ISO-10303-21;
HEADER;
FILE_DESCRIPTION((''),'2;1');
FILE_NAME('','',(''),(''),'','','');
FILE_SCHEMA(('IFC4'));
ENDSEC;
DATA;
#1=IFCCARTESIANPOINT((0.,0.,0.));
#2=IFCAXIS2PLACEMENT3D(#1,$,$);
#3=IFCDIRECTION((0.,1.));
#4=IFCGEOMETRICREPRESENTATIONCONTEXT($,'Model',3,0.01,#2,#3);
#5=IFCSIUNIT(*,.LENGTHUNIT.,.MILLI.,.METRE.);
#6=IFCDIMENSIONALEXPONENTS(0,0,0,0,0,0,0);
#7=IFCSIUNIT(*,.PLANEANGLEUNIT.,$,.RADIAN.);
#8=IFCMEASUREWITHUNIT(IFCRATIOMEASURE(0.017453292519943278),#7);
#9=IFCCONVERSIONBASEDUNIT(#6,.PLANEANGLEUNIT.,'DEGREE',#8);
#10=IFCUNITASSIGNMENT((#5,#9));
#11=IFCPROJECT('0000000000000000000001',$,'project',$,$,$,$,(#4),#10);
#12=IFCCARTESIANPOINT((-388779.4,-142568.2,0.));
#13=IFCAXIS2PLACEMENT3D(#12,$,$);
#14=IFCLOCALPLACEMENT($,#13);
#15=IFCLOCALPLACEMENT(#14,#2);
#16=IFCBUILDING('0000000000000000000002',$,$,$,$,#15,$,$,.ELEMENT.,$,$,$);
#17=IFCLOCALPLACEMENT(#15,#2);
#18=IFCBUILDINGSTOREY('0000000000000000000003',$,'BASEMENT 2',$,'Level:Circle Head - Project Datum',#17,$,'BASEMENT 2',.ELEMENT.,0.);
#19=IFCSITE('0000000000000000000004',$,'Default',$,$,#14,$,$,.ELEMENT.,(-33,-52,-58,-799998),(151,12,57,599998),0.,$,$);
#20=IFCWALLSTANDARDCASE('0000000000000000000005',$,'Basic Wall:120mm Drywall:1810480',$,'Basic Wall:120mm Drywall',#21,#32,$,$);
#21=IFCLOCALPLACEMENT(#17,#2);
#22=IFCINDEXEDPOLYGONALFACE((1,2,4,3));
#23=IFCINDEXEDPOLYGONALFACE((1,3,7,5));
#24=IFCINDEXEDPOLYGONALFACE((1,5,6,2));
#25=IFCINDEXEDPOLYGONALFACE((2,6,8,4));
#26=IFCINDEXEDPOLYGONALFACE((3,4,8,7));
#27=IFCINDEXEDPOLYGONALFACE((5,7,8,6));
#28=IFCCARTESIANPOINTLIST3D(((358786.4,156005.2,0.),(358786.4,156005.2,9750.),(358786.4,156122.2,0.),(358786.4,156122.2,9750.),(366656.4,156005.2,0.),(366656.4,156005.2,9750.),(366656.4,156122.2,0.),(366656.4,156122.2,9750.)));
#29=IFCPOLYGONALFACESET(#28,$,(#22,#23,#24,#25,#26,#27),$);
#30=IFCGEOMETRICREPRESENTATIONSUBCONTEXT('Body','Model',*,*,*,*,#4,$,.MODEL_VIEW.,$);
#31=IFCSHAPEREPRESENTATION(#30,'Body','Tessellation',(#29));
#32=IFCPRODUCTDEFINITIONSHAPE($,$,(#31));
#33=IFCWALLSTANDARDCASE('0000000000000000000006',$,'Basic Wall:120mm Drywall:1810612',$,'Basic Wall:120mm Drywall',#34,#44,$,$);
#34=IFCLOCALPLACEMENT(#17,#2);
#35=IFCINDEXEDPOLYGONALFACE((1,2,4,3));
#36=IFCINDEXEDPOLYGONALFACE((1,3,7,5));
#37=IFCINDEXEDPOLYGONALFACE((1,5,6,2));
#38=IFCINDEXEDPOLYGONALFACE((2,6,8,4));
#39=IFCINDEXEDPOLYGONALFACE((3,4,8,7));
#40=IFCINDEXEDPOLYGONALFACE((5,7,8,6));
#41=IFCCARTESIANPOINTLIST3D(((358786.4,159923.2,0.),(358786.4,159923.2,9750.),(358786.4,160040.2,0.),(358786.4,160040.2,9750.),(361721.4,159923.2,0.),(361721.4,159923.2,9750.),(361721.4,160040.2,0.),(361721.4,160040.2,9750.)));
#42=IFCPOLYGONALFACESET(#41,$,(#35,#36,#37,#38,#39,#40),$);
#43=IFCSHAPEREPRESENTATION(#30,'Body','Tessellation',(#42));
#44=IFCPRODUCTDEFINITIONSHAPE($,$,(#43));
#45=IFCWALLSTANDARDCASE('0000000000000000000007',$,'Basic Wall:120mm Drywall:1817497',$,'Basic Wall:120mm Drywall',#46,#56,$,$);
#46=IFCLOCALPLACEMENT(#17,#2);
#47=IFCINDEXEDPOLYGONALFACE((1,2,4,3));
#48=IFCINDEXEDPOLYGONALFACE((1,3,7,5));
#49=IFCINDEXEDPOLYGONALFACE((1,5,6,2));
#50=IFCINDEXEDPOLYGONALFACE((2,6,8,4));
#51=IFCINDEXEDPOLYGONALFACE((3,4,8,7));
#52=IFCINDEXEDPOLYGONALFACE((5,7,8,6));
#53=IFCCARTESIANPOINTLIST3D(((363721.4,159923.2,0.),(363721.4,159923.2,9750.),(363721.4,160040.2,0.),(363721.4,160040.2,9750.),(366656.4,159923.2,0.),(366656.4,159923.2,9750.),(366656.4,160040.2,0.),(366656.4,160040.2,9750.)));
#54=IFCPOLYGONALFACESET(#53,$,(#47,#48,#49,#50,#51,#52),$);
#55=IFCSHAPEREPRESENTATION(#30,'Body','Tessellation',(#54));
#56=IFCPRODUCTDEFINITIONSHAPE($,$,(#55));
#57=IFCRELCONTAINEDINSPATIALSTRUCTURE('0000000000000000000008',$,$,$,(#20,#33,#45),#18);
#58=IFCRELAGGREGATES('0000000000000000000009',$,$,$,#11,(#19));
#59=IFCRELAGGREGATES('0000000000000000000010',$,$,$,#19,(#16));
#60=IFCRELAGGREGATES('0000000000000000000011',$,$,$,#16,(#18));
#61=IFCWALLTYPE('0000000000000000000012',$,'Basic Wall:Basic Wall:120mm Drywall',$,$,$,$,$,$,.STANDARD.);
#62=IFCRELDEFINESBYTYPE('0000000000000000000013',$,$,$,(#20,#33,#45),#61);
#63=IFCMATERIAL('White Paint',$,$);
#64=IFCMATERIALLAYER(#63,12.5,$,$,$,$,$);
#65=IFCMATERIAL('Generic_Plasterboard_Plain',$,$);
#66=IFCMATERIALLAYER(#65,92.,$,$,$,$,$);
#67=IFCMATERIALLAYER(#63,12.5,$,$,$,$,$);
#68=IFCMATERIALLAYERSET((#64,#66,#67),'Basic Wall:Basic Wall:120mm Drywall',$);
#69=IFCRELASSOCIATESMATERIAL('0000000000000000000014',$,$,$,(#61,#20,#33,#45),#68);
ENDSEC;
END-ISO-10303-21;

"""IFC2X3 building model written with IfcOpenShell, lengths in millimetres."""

from ifc_helpers import new_model, entity, si_unit, converted_unit, direction, frame, frame_2d, origin, place, context, subcontext, project, spatial, rectangle, extrude, material, layer, layer_set, layer_usage, type_object, element, save


model = new_model("IFC2X3")

# Units and contexts
model_context = context("Model", 3, precision=0.01, world=origin(), true_north=direction((0.0, 1.0)))
body_context = subcontext(model_context, "Body", "Model", "MODEL_VIEW")
ifc_project = project(units=[si_unit("LENGTHUNIT", "METRE", prefix="MILLI"), converted_unit("PLANEANGLEUNIT", "DEGREE", entity("IfcRatioMeasure", 0.017453292519943278), si_unit("PLANEANGLEUNIT", "RADIAN"), dimensions=[0, 0, 0, 0, 0, 0, 0])], contexts=[model_context])

# Site, building, storey
site_placement = place(None, frame((-388779.4, -142568.2, 0.0)))
site = spatial("IfcSite", under=ifc_project, at=site_placement, Name="Default", CompositionType="ELEMENT", RefLatitude=(-33, -52, -58, -799998), RefLongitude=(151, 12, 57, 599998), RefElevation=0.0)
building_placement = place(site_placement, origin())
building = spatial("IfcBuilding", under=site, at=building_placement, CompositionType="ELEMENT")
storey_placement = place(building_placement, origin())
storey = spatial("IfcBuildingStorey", under=building, at=storey_placement, Name="BASEMENT 2", ObjectType="Level:Circle Head - Project Datum", LongName="BASEMENT 2", CompositionType="ELEMENT", Elevation=0.0)

# Shared definitions
ifc_material_1 = material(Name="White Paint")
ifc_layer_1 = layer(ifc_material_1, 12.5)
ifc_material_2 = material(Name="Generic_Plasterboard_Plain")
ifc_layer_2 = layer(ifc_material_2, 92.0)
ifc_layer_3 = layer(ifc_material_1, 12.5)
ifc_layer_set_1 = layer_set([ifc_layer_1, ifc_layer_2, ifc_layer_3], Name="Basic Wall:Basic Wall:120mm Drywall")
wall_type_1 = type_object("IfcWallType", Name="Basic Wall:Basic Wall:120mm Drywall", PredefinedType="STANDARD", material=ifc_layer_set_1)

# Walls
ifc_layer_usage_1 = layer_usage(ifc_layer_set_1, "AXIS2", "NEGATIVE", 58.5)
wall_1_placement = place(storey_placement, frame((358786.4, 156063.7, 0.0)))
element("IfcWallStandardCase", 1, at=wall_1_placement, inside=storey, type_object=wall_type_1, material=ifc_layer_usage_1, Name="Basic Wall:120mm Drywall:1810480", ObjectType="Basic Wall:120mm Drywall", context=body_context, shape_type="SweptSolid", body=[
    extrude(rectangle(XDim=7870.0, YDim=117.0, at=frame_2d((3935.0, 0.0), x_axis=(-1.0, 0.0))), origin(), (0.0, 0.0, 1.0), 9750.0),
])
ifc_layer_usage_2 = layer_usage(ifc_layer_set_1, "AXIS2", "NEGATIVE", 58.5)
wall_2_placement = place(storey_placement, frame((358786.4, 159981.7, 0.0)))
element("IfcWallStandardCase", 2, at=wall_2_placement, inside=storey, type_object=wall_type_1, material=ifc_layer_usage_2, Name="Basic Wall:120mm Drywall:1810612", ObjectType="Basic Wall:120mm Drywall", context=body_context, shape_type="SweptSolid", body=[
    extrude(rectangle(XDim=2935.0, YDim=117.0, at=frame_2d((1467.5, 0.0), x_axis=(-1.0, 0.0))), origin(), (0.0, 0.0, 1.0), 9750.0),
])
ifc_layer_usage_3 = layer_usage(ifc_layer_set_1, "AXIS2", "NEGATIVE", 58.5)
wall_3_placement = place(storey_placement, frame((363721.4, 159981.7, 0.0)))
element("IfcWallStandardCase", 3, at=wall_3_placement, inside=storey, type_object=wall_type_1, material=ifc_layer_usage_3, Name="Basic Wall:120mm Drywall:1817497", ObjectType="Basic Wall:120mm Drywall", context=body_context, shape_type="SweptSolid", body=[
    extrude(rectangle(XDim=2935.0, YDim=117.0, at=frame_2d((1467.5, 0.0), x_axis=(-1.0, 0.0))), origin(), (0.0, 0.0, 1.0), 9750.0),
])

save(model, "model.ifc")
